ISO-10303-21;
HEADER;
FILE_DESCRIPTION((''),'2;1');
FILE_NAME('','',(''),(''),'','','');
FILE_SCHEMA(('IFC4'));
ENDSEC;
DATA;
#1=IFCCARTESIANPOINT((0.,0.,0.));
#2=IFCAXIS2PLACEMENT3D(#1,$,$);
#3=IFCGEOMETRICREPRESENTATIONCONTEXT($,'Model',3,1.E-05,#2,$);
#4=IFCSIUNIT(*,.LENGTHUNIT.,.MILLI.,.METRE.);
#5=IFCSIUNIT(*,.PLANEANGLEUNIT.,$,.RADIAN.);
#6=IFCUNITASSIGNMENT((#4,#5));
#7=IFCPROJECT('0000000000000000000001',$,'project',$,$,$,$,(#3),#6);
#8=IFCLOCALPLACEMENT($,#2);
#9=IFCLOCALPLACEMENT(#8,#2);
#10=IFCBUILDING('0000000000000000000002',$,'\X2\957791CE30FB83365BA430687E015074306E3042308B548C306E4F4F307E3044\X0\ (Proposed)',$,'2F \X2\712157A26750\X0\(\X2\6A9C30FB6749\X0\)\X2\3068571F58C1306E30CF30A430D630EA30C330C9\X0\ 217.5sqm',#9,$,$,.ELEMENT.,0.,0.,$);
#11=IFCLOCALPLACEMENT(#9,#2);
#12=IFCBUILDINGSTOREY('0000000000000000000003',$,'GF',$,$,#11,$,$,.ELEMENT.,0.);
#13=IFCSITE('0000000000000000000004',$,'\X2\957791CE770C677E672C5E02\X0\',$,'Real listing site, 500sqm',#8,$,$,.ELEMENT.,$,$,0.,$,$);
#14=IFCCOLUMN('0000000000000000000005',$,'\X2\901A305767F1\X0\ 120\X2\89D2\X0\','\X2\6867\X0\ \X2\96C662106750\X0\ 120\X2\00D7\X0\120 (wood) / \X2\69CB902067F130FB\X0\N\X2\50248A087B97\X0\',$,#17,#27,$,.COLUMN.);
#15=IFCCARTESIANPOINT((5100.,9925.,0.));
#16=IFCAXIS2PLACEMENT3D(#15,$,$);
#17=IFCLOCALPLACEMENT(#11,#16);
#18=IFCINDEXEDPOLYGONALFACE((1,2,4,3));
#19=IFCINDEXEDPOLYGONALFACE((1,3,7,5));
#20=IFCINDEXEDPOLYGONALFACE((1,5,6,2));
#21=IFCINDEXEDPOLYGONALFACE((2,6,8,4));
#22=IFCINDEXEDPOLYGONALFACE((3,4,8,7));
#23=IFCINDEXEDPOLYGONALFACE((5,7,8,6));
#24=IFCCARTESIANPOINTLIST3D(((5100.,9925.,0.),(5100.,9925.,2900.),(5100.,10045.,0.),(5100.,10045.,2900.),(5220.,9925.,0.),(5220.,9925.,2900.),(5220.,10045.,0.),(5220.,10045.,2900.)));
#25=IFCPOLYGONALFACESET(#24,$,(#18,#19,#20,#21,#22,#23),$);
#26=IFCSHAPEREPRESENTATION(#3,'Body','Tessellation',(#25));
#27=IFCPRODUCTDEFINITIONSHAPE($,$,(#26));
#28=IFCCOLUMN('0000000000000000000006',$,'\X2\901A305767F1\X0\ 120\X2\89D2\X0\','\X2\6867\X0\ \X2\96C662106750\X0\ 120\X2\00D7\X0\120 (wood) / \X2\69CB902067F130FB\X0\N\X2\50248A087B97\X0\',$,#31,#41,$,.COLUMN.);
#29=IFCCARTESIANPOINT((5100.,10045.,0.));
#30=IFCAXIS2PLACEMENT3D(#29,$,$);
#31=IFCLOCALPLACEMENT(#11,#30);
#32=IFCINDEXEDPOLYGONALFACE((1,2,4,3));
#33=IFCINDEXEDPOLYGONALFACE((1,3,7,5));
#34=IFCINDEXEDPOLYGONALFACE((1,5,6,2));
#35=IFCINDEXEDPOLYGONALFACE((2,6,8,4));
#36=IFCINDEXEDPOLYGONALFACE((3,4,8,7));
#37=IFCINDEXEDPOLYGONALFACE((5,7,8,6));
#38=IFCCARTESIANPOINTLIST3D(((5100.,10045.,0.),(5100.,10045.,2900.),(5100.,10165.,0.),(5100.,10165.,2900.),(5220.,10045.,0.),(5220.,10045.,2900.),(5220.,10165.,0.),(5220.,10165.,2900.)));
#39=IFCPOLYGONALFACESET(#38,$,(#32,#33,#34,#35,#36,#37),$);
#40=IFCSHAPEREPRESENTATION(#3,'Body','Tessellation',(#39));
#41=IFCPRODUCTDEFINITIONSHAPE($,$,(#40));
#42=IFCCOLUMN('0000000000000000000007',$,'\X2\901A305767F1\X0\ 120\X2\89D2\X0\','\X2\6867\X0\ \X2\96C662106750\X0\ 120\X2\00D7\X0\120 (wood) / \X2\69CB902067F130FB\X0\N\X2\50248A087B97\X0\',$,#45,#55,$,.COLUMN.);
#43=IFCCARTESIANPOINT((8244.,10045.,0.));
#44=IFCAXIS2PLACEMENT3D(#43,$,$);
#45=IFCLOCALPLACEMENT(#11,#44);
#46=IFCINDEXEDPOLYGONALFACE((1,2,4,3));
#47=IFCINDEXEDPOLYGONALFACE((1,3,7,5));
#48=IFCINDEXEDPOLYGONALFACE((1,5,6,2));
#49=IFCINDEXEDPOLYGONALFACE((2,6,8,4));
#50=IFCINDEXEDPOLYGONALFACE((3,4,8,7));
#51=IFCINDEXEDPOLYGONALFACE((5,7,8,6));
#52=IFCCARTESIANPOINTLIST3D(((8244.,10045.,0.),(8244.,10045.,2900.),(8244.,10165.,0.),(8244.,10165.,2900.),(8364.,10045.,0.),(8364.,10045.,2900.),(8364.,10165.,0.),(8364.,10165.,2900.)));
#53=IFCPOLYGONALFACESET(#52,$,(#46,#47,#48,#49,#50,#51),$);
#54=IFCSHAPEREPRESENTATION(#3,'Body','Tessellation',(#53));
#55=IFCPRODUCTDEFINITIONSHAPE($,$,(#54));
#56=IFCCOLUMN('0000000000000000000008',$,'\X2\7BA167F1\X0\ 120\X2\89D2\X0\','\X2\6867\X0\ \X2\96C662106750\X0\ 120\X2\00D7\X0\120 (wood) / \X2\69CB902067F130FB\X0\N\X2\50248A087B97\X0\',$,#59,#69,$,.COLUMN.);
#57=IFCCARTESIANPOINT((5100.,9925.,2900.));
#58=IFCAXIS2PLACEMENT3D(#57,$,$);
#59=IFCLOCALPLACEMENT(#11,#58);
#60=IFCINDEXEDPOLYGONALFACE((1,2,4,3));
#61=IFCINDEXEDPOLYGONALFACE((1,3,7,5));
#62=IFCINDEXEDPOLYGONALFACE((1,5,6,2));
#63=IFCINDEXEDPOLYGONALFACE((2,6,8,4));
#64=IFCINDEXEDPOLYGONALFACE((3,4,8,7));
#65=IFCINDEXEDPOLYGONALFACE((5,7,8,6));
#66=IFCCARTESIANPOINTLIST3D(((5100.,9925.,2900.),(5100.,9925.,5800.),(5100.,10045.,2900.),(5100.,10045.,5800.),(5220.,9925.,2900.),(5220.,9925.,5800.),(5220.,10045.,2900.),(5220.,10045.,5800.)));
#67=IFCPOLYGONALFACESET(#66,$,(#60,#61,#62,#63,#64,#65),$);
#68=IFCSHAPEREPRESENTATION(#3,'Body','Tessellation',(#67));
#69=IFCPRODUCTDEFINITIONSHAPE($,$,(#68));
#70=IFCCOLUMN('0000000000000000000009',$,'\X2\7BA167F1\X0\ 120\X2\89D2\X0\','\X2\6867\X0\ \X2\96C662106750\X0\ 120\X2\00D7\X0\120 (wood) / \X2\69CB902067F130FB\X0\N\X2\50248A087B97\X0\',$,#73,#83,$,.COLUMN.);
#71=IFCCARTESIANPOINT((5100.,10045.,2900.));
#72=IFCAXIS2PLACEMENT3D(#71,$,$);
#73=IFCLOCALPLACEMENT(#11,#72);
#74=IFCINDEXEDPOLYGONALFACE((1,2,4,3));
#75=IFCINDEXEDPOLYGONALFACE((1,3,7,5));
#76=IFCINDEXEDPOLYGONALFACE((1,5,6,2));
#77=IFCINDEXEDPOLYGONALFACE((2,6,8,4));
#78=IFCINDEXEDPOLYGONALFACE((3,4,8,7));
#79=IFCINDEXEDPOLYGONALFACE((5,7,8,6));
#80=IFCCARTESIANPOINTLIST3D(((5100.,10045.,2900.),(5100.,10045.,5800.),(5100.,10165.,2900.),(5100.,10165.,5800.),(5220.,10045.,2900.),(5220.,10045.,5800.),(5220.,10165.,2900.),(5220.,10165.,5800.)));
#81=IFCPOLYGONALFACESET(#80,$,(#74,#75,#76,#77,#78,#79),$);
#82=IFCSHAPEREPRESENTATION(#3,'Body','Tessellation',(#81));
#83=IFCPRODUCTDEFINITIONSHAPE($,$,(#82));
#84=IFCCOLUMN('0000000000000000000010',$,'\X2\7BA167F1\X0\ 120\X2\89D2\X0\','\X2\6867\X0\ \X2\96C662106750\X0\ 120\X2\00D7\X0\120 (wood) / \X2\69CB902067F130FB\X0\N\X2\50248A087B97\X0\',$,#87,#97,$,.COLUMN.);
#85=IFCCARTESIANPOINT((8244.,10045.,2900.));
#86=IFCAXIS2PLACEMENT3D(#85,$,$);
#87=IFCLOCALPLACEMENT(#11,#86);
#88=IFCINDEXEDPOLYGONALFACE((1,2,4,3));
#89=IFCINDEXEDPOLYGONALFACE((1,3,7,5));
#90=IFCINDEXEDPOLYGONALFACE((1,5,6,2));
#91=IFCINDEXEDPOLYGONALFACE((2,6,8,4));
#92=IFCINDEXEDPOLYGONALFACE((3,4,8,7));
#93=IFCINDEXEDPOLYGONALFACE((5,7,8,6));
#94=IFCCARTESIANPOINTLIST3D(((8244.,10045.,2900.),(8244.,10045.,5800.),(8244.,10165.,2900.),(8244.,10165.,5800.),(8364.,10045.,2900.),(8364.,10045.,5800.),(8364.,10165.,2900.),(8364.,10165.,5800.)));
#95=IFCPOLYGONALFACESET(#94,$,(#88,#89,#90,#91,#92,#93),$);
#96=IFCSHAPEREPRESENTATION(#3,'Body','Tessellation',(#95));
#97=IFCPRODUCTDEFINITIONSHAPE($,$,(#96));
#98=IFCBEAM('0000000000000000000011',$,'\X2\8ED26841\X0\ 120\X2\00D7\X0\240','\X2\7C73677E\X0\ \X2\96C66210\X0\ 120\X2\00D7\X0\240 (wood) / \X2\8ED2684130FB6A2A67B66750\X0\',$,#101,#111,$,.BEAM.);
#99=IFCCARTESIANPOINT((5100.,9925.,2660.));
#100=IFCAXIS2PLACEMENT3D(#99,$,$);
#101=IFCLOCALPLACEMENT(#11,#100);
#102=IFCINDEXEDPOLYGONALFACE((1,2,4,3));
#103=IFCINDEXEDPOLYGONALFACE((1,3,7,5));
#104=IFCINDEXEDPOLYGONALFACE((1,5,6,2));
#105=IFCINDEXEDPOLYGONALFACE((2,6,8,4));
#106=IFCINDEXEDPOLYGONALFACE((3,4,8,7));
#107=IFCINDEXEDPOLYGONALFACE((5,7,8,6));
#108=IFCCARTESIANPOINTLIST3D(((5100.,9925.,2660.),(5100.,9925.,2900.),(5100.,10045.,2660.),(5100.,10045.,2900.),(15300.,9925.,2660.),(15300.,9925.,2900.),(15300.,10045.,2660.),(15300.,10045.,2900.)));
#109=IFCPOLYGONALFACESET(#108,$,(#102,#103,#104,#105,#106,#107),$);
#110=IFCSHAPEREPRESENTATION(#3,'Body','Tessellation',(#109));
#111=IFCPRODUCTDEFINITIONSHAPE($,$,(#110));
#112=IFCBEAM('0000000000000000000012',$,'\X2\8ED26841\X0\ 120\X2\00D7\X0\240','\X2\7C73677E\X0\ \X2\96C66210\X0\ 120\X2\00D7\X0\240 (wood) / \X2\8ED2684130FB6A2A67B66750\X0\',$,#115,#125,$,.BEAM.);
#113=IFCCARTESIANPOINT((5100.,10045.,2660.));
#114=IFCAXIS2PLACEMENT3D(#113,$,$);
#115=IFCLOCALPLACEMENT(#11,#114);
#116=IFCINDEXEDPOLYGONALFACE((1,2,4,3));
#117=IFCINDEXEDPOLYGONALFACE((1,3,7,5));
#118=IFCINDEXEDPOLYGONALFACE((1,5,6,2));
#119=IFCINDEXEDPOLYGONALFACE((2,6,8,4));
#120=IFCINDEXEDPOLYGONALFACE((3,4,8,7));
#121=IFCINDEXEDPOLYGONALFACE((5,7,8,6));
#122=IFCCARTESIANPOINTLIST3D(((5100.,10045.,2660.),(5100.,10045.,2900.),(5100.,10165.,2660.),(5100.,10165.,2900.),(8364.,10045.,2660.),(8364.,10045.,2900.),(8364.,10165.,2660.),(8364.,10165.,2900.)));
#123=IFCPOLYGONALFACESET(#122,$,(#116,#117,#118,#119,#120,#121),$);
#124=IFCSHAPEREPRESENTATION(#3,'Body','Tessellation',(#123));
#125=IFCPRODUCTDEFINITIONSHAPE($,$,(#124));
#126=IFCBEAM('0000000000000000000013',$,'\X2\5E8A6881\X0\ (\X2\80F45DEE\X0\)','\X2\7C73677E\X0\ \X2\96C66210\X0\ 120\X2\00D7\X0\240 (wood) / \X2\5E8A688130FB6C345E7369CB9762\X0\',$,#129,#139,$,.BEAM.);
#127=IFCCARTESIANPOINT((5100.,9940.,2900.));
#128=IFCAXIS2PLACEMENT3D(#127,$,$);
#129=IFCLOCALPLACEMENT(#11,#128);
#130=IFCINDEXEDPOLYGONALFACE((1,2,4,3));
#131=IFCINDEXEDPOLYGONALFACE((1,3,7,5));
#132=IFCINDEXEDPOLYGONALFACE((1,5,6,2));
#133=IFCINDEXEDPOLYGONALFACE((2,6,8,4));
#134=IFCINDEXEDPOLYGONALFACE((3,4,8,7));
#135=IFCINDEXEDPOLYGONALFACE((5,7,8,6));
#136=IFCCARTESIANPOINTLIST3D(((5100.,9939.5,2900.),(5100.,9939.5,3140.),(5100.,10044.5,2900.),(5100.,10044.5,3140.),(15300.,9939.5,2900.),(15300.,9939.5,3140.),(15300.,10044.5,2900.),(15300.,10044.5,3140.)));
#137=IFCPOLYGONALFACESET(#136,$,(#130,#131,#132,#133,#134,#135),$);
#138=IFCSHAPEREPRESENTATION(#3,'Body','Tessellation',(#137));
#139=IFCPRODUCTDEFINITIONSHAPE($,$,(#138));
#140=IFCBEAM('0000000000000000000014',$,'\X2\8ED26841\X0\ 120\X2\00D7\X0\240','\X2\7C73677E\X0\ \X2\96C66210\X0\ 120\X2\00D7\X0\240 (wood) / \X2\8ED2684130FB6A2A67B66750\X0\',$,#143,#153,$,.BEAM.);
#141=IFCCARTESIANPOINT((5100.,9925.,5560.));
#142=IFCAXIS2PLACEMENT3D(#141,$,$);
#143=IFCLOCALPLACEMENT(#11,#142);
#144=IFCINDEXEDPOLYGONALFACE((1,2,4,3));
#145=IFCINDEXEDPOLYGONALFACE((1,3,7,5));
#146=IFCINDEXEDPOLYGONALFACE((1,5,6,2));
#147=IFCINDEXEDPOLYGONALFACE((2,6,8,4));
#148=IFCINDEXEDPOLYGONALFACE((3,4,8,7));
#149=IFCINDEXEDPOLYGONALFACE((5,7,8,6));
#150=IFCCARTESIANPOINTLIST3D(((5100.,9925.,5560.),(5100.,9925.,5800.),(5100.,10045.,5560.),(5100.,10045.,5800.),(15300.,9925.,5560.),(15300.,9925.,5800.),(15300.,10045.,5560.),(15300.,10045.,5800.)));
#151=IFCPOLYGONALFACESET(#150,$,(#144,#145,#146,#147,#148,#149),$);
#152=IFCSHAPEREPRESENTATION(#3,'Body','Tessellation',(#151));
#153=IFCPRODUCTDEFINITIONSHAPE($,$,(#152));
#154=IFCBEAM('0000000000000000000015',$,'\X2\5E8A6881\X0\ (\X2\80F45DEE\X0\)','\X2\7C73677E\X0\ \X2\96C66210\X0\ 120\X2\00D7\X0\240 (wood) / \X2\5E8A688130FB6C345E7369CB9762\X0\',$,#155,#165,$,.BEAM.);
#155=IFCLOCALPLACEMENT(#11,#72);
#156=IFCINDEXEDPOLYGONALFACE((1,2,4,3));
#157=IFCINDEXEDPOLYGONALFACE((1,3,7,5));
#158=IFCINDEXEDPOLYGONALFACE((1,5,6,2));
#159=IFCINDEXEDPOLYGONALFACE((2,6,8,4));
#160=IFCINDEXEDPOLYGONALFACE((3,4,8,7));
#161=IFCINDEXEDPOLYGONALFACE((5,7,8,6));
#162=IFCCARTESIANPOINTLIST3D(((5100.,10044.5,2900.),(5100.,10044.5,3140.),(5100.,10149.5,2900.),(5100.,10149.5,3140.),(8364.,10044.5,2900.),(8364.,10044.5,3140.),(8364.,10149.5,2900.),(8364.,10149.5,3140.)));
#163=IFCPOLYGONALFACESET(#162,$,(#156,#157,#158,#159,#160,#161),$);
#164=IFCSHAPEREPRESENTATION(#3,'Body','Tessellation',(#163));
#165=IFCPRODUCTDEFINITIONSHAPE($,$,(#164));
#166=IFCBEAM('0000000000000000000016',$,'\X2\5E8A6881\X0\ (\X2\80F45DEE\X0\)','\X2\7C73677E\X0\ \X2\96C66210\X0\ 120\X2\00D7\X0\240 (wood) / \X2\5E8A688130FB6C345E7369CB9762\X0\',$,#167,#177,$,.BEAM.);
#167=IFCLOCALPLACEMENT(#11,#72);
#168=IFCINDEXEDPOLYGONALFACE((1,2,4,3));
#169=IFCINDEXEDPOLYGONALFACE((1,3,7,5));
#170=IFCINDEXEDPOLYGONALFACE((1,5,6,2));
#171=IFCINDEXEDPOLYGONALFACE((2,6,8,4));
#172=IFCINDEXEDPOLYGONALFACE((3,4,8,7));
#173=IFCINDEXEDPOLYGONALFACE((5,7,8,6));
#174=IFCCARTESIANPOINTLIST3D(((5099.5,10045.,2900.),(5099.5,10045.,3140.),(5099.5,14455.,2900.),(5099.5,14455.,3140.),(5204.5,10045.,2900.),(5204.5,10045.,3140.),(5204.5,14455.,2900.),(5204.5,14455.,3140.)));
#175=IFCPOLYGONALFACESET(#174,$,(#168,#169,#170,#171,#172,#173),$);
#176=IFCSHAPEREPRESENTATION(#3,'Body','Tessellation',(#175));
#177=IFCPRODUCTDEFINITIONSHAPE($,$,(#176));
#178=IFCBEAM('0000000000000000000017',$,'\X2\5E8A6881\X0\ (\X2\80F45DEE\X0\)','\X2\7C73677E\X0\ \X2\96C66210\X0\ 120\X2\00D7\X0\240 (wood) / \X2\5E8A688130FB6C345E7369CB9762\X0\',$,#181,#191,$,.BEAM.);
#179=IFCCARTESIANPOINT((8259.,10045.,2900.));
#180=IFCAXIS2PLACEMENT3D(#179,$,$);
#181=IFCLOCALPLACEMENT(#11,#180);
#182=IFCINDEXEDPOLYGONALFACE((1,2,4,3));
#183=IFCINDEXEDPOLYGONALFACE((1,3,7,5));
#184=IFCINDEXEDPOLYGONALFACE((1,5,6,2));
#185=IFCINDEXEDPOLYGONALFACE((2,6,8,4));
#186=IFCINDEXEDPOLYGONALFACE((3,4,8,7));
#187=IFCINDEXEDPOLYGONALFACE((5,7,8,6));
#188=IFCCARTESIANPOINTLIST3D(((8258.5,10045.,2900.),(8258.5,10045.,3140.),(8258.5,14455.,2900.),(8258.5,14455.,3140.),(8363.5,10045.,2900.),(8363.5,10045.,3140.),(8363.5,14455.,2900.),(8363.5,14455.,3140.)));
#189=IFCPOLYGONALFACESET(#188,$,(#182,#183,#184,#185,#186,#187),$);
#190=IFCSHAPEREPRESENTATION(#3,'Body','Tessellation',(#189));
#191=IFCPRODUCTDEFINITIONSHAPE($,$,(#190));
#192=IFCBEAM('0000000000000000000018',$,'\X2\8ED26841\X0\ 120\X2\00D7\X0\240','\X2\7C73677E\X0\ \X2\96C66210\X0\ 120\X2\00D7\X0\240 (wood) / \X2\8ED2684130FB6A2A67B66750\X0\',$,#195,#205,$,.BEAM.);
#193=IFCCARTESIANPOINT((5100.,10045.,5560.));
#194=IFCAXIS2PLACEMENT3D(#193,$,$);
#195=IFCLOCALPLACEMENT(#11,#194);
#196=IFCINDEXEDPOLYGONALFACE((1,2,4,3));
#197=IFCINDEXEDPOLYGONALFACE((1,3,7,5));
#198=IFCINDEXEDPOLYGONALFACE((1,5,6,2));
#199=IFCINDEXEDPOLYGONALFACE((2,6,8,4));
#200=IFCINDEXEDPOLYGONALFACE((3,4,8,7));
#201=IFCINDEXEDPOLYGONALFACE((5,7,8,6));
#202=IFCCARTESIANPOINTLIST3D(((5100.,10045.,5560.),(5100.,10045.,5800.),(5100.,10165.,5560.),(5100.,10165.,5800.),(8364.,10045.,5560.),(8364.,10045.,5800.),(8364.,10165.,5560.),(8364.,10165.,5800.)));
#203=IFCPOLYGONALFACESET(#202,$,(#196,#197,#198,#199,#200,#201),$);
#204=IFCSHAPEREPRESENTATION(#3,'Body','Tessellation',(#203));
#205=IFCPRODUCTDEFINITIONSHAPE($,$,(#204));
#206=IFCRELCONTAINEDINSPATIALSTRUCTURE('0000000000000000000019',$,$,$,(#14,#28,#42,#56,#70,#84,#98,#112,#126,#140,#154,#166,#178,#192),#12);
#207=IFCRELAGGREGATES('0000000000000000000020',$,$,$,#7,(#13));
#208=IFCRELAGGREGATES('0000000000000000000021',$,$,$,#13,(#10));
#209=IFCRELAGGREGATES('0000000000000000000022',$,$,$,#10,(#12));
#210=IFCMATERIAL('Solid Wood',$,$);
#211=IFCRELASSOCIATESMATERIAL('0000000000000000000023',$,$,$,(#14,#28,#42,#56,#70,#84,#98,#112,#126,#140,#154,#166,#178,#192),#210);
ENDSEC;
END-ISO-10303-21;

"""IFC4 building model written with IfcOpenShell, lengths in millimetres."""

from ifc_helpers import new_model, si_unit, frame, frame_2d, origin, place, context, project, spatial, rectangle, extrude, material, element, save


model = new_model("IFC4")

# Units and contexts
model_context = context("Model", 3, precision=1e-05, world=origin())
ifc_project = project(units=[si_unit("LENGTHUNIT", "METRE", prefix="MILLI"), si_unit("PLANEANGLEUNIT", "RADIAN")], contexts=[model_context])

# Site, building, storey
site_placement = place(None, origin())
site = spatial("IfcSite", under=ifc_project, at=site_placement, Name="長野県松本市", ObjectType="Real listing site, 500sqm", CompositionType="ELEMENT", RefElevation=0.0)
building_placement = place(site_placement, origin())
building = spatial("IfcBuilding", under=site, at=building_placement, Name="長野・茶室と縁側のある和の住まい (Proposed)", ObjectType="2F 無垢材(檜・杉)と土壁のハイブリッド 217.5sqm", CompositionType="ELEMENT", ElevationOfRefHeight=0.0, ElevationOfTerrain=0.0)
storey_placement = place(building_placement, origin())
storey = spatial("IfcBuildingStorey", under=building, at=storey_placement, Name="GF", CompositionType="ELEMENT", Elevation=0.0)

# Columns
ifc_material_1 = material(Name="Solid Wood")
column_1_placement = place(storey_placement, frame((5100.0, 9925.0, 0.0)))
element("IfcColumn", 1, at=column_1_placement, inside=storey, material=ifc_material_1, Name="通し柱 120角", Description="桧 集成材 120×120 (wood) / 構造柱・N値計算", PredefinedType="COLUMN", context=model_context, shape_type="SweptSolid", body=[
    extrude(rectangle(XDim=120.0, YDim=120.0, at=frame_2d((60.0, 60.0))), frame((5100.0, 9925.0, 0.0)), (0.0, 0.0, 1.0), 2900.0),
])
column_2_placement = place(storey_placement, frame((5100.0, 10045.0, 0.0)))
element("IfcColumn", 2, at=column_2_placement, inside=storey, material=ifc_material_1, Name="通し柱 120角", Description="桧 集成材 120×120 (wood) / 構造柱・N値計算", PredefinedType="COLUMN", context=model_context, shape_type="SweptSolid", body=[
    extrude(rectangle(XDim=120.0, YDim=120.0, at=frame_2d((60.0, 60.0))), frame((5100.0, 10045.0, 0.0)), (0.0, 0.0, 1.0), 2900.0),
])
column_3_placement = place(storey_placement, frame((8244.0, 10045.0, 0.0)))
element("IfcColumn", 3, at=column_3_placement, inside=storey, material=ifc_material_1, Name="通し柱 120角", Description="桧 集成材 120×120 (wood) / 構造柱・N値計算", PredefinedType="COLUMN", context=model_context, shape_type="SweptSolid", body=[
    extrude(rectangle(XDim=120.0, YDim=120.0, at=frame_2d((60.0, 60.0))), frame((8244.0, 10045.0, 0.0)), (0.0, 0.0, 1.0), 2900.0),
])
column_4_placement = place(storey_placement, frame((5100.0, 9925.0, 2900.0)))
element("IfcColumn", 4, at=column_4_placement, inside=storey, material=ifc_material_1, Name="管柱 120角", Description="桧 集成材 120×120 (wood) / 構造柱・N値計算", PredefinedType="COLUMN", context=model_context, shape_type="SweptSolid", body=[
    extrude(rectangle(XDim=120.0, YDim=120.0, at=frame_2d((60.0, 60.0))), frame((5100.0, 9925.0, 2900.0)), (0.0, 0.0, 1.0), 2900.0),
])
column_5_placement = place(storey_placement, frame((5100.0, 10045.0, 2900.0)))
element("IfcColumn", 5, at=column_5_placement, inside=storey, material=ifc_material_1, Name="管柱 120角", Description="桧 集成材 120×120 (wood) / 構造柱・N値計算", PredefinedType="COLUMN", context=model_context, shape_type="SweptSolid", body=[
    extrude(rectangle(XDim=120.0, YDim=120.0, at=frame_2d((60.0, 60.0))), frame((5100.0, 10045.0, 2900.0)), (0.0, 0.0, 1.0), 2900.0),
])
column_6_placement = place(storey_placement, frame((8244.0, 10045.0, 2900.0)))
element("IfcColumn", 6, at=column_6_placement, inside=storey, material=ifc_material_1, Name="管柱 120角", Description="桧 集成材 120×120 (wood) / 構造柱・N値計算", PredefinedType="COLUMN", context=model_context, shape_type="SweptSolid", body=[
    extrude(rectangle(XDim=120.0, YDim=120.0, at=frame_2d((60.0, 60.0))), frame((8244.0, 10045.0, 2900.0)), (0.0, 0.0, 1.0), 2900.0),
])

# Beams
beam_1_placement = place(storey_placement, frame((5100.0, 9925.0, 2660.0)))
element("IfcBeam", 7, at=beam_1_placement, inside=storey, material=ifc_material_1, Name="軒桁 120×240", Description="米松 集成 120×240 (wood) / 軒桁・横架材", PredefinedType="BEAM", context=model_context, shape_type="SweptSolid", body=[
    extrude(rectangle(XDim=10200.0, YDim=120.0, at=frame_2d((5100.0, 60.0))), frame((5100.0, 9925.0, 2660.0)), (0.0, 0.0, 1.0), 240.0),
])
beam_2_placement = place(storey_placement, frame((5100.0, 10045.0, 2660.0)))
element("IfcBeam", 8, at=beam_2_placement, inside=storey, material=ifc_material_1, Name="軒桁 120×240", Description="米松 集成 120×240 (wood) / 軒桁・横架材", PredefinedType="BEAM", context=model_context, shape_type="SweptSolid", body=[
    extrude(rectangle(XDim=3264.0, YDim=120.0, at=frame_2d((1632.0, 60.0))), frame((5100.0, 10045.0, 2660.0)), (0.0, 0.0, 1.0), 240.0),
])
beam_3_placement = place(storey_placement, frame((5100.0, 9940.0, 2900.0)))
element("IfcBeam", 9, at=beam_3_placement, inside=storey, material=ifc_material_1, Name="床梁 (胴差)", Description="米松 集成 120×240 (wood) / 床梁・水平構面", PredefinedType="BEAM", context=model_context, shape_type="SweptSolid", body=[
    extrude(rectangle(XDim=10200.0, YDim=105.0, at=frame_2d((5100.0, 52.0))), frame((5100.0, 9940.0, 2900.0)), (0.0, 0.0, 1.0), 240.0),
])
beam_4_placement = place(storey_placement, frame((5100.0, 9925.0, 5560.0)))
element("IfcBeam", 10, at=beam_4_placement, inside=storey, material=ifc_material_1, Name="軒桁 120×240", Description="米松 集成 120×240 (wood) / 軒桁・横架材", PredefinedType="BEAM", context=model_context, shape_type="SweptSolid", body=[
    extrude(rectangle(XDim=10200.0, YDim=120.0, at=frame_2d((5100.0, 60.0))), frame((5100.0, 9925.0, 5560.0)), (0.0, 0.0, 1.0), 240.0),
])
beam_5_placement = place(storey_placement, frame((5100.0, 10045.0, 2900.0)))
element("IfcBeam", 11, at=beam_5_placement, inside=storey, material=ifc_material_1, Name="床梁 (胴差)", Description="米松 集成 120×240 (wood) / 床梁・水平構面", PredefinedType="BEAM", context=model_context, shape_type="SweptSolid", body=[
    extrude(rectangle(XDim=3264.0, YDim=105.0, at=frame_2d((1632.0, 52.0))), frame((5100.0, 10045.0, 2900.0)), (0.0, 0.0, 1.0), 240.0),
])
beam_6_placement = place(storey_placement, frame((5100.0, 10045.0, 2900.0)))
element("IfcBeam", 12, at=beam_6_placement, inside=storey, material=ifc_material_1, Name="床梁 (胴差)", Description="米松 集成 120×240 (wood) / 床梁・水平構面", PredefinedType="BEAM", context=model_context, shape_type="SweptSolid", body=[
    extrude(rectangle(XDim=105.0, YDim=4410.0, at=frame_2d((52.0, 2205.0))), frame((5100.0, 10045.0, 2900.0)), (0.0, 0.0, 1.0), 240.0),
])
beam_7_placement = place(storey_placement, frame((8259.0, 10045.0, 2900.0)))
element("IfcBeam", 13, at=beam_7_placement, inside=storey, material=ifc_material_1, Name="床梁 (胴差)", Description="米松 集成 120×240 (wood) / 床梁・水平構面", PredefinedType="BEAM", context=model_context, shape_type="SweptSolid", body=[
    extrude(rectangle(XDim=105.0, YDim=4410.0, at=frame_2d((52.0, 2205.0))), frame((8259.0, 10045.0, 2900.0)), (0.0, 0.0, 1.0), 240.0),
])
beam_8_placement = place(storey_placement, frame((5100.0, 10045.0, 5560.0)))
element("IfcBeam", 14, at=beam_8_placement, inside=storey, material=ifc_material_1, Name="軒桁 120×240", Description="米松 集成 120×240 (wood) / 軒桁・横架材", PredefinedType="BEAM", context=model_context, shape_type="SweptSolid", body=[
    extrude(rectangle(XDim=3264.0, YDim=120.0, at=frame_2d((1632.0, 60.0))), frame((5100.0, 10045.0, 5560.0)), (0.0, 0.0, 1.0), 240.0),
])

save(model, "model.ifc")
